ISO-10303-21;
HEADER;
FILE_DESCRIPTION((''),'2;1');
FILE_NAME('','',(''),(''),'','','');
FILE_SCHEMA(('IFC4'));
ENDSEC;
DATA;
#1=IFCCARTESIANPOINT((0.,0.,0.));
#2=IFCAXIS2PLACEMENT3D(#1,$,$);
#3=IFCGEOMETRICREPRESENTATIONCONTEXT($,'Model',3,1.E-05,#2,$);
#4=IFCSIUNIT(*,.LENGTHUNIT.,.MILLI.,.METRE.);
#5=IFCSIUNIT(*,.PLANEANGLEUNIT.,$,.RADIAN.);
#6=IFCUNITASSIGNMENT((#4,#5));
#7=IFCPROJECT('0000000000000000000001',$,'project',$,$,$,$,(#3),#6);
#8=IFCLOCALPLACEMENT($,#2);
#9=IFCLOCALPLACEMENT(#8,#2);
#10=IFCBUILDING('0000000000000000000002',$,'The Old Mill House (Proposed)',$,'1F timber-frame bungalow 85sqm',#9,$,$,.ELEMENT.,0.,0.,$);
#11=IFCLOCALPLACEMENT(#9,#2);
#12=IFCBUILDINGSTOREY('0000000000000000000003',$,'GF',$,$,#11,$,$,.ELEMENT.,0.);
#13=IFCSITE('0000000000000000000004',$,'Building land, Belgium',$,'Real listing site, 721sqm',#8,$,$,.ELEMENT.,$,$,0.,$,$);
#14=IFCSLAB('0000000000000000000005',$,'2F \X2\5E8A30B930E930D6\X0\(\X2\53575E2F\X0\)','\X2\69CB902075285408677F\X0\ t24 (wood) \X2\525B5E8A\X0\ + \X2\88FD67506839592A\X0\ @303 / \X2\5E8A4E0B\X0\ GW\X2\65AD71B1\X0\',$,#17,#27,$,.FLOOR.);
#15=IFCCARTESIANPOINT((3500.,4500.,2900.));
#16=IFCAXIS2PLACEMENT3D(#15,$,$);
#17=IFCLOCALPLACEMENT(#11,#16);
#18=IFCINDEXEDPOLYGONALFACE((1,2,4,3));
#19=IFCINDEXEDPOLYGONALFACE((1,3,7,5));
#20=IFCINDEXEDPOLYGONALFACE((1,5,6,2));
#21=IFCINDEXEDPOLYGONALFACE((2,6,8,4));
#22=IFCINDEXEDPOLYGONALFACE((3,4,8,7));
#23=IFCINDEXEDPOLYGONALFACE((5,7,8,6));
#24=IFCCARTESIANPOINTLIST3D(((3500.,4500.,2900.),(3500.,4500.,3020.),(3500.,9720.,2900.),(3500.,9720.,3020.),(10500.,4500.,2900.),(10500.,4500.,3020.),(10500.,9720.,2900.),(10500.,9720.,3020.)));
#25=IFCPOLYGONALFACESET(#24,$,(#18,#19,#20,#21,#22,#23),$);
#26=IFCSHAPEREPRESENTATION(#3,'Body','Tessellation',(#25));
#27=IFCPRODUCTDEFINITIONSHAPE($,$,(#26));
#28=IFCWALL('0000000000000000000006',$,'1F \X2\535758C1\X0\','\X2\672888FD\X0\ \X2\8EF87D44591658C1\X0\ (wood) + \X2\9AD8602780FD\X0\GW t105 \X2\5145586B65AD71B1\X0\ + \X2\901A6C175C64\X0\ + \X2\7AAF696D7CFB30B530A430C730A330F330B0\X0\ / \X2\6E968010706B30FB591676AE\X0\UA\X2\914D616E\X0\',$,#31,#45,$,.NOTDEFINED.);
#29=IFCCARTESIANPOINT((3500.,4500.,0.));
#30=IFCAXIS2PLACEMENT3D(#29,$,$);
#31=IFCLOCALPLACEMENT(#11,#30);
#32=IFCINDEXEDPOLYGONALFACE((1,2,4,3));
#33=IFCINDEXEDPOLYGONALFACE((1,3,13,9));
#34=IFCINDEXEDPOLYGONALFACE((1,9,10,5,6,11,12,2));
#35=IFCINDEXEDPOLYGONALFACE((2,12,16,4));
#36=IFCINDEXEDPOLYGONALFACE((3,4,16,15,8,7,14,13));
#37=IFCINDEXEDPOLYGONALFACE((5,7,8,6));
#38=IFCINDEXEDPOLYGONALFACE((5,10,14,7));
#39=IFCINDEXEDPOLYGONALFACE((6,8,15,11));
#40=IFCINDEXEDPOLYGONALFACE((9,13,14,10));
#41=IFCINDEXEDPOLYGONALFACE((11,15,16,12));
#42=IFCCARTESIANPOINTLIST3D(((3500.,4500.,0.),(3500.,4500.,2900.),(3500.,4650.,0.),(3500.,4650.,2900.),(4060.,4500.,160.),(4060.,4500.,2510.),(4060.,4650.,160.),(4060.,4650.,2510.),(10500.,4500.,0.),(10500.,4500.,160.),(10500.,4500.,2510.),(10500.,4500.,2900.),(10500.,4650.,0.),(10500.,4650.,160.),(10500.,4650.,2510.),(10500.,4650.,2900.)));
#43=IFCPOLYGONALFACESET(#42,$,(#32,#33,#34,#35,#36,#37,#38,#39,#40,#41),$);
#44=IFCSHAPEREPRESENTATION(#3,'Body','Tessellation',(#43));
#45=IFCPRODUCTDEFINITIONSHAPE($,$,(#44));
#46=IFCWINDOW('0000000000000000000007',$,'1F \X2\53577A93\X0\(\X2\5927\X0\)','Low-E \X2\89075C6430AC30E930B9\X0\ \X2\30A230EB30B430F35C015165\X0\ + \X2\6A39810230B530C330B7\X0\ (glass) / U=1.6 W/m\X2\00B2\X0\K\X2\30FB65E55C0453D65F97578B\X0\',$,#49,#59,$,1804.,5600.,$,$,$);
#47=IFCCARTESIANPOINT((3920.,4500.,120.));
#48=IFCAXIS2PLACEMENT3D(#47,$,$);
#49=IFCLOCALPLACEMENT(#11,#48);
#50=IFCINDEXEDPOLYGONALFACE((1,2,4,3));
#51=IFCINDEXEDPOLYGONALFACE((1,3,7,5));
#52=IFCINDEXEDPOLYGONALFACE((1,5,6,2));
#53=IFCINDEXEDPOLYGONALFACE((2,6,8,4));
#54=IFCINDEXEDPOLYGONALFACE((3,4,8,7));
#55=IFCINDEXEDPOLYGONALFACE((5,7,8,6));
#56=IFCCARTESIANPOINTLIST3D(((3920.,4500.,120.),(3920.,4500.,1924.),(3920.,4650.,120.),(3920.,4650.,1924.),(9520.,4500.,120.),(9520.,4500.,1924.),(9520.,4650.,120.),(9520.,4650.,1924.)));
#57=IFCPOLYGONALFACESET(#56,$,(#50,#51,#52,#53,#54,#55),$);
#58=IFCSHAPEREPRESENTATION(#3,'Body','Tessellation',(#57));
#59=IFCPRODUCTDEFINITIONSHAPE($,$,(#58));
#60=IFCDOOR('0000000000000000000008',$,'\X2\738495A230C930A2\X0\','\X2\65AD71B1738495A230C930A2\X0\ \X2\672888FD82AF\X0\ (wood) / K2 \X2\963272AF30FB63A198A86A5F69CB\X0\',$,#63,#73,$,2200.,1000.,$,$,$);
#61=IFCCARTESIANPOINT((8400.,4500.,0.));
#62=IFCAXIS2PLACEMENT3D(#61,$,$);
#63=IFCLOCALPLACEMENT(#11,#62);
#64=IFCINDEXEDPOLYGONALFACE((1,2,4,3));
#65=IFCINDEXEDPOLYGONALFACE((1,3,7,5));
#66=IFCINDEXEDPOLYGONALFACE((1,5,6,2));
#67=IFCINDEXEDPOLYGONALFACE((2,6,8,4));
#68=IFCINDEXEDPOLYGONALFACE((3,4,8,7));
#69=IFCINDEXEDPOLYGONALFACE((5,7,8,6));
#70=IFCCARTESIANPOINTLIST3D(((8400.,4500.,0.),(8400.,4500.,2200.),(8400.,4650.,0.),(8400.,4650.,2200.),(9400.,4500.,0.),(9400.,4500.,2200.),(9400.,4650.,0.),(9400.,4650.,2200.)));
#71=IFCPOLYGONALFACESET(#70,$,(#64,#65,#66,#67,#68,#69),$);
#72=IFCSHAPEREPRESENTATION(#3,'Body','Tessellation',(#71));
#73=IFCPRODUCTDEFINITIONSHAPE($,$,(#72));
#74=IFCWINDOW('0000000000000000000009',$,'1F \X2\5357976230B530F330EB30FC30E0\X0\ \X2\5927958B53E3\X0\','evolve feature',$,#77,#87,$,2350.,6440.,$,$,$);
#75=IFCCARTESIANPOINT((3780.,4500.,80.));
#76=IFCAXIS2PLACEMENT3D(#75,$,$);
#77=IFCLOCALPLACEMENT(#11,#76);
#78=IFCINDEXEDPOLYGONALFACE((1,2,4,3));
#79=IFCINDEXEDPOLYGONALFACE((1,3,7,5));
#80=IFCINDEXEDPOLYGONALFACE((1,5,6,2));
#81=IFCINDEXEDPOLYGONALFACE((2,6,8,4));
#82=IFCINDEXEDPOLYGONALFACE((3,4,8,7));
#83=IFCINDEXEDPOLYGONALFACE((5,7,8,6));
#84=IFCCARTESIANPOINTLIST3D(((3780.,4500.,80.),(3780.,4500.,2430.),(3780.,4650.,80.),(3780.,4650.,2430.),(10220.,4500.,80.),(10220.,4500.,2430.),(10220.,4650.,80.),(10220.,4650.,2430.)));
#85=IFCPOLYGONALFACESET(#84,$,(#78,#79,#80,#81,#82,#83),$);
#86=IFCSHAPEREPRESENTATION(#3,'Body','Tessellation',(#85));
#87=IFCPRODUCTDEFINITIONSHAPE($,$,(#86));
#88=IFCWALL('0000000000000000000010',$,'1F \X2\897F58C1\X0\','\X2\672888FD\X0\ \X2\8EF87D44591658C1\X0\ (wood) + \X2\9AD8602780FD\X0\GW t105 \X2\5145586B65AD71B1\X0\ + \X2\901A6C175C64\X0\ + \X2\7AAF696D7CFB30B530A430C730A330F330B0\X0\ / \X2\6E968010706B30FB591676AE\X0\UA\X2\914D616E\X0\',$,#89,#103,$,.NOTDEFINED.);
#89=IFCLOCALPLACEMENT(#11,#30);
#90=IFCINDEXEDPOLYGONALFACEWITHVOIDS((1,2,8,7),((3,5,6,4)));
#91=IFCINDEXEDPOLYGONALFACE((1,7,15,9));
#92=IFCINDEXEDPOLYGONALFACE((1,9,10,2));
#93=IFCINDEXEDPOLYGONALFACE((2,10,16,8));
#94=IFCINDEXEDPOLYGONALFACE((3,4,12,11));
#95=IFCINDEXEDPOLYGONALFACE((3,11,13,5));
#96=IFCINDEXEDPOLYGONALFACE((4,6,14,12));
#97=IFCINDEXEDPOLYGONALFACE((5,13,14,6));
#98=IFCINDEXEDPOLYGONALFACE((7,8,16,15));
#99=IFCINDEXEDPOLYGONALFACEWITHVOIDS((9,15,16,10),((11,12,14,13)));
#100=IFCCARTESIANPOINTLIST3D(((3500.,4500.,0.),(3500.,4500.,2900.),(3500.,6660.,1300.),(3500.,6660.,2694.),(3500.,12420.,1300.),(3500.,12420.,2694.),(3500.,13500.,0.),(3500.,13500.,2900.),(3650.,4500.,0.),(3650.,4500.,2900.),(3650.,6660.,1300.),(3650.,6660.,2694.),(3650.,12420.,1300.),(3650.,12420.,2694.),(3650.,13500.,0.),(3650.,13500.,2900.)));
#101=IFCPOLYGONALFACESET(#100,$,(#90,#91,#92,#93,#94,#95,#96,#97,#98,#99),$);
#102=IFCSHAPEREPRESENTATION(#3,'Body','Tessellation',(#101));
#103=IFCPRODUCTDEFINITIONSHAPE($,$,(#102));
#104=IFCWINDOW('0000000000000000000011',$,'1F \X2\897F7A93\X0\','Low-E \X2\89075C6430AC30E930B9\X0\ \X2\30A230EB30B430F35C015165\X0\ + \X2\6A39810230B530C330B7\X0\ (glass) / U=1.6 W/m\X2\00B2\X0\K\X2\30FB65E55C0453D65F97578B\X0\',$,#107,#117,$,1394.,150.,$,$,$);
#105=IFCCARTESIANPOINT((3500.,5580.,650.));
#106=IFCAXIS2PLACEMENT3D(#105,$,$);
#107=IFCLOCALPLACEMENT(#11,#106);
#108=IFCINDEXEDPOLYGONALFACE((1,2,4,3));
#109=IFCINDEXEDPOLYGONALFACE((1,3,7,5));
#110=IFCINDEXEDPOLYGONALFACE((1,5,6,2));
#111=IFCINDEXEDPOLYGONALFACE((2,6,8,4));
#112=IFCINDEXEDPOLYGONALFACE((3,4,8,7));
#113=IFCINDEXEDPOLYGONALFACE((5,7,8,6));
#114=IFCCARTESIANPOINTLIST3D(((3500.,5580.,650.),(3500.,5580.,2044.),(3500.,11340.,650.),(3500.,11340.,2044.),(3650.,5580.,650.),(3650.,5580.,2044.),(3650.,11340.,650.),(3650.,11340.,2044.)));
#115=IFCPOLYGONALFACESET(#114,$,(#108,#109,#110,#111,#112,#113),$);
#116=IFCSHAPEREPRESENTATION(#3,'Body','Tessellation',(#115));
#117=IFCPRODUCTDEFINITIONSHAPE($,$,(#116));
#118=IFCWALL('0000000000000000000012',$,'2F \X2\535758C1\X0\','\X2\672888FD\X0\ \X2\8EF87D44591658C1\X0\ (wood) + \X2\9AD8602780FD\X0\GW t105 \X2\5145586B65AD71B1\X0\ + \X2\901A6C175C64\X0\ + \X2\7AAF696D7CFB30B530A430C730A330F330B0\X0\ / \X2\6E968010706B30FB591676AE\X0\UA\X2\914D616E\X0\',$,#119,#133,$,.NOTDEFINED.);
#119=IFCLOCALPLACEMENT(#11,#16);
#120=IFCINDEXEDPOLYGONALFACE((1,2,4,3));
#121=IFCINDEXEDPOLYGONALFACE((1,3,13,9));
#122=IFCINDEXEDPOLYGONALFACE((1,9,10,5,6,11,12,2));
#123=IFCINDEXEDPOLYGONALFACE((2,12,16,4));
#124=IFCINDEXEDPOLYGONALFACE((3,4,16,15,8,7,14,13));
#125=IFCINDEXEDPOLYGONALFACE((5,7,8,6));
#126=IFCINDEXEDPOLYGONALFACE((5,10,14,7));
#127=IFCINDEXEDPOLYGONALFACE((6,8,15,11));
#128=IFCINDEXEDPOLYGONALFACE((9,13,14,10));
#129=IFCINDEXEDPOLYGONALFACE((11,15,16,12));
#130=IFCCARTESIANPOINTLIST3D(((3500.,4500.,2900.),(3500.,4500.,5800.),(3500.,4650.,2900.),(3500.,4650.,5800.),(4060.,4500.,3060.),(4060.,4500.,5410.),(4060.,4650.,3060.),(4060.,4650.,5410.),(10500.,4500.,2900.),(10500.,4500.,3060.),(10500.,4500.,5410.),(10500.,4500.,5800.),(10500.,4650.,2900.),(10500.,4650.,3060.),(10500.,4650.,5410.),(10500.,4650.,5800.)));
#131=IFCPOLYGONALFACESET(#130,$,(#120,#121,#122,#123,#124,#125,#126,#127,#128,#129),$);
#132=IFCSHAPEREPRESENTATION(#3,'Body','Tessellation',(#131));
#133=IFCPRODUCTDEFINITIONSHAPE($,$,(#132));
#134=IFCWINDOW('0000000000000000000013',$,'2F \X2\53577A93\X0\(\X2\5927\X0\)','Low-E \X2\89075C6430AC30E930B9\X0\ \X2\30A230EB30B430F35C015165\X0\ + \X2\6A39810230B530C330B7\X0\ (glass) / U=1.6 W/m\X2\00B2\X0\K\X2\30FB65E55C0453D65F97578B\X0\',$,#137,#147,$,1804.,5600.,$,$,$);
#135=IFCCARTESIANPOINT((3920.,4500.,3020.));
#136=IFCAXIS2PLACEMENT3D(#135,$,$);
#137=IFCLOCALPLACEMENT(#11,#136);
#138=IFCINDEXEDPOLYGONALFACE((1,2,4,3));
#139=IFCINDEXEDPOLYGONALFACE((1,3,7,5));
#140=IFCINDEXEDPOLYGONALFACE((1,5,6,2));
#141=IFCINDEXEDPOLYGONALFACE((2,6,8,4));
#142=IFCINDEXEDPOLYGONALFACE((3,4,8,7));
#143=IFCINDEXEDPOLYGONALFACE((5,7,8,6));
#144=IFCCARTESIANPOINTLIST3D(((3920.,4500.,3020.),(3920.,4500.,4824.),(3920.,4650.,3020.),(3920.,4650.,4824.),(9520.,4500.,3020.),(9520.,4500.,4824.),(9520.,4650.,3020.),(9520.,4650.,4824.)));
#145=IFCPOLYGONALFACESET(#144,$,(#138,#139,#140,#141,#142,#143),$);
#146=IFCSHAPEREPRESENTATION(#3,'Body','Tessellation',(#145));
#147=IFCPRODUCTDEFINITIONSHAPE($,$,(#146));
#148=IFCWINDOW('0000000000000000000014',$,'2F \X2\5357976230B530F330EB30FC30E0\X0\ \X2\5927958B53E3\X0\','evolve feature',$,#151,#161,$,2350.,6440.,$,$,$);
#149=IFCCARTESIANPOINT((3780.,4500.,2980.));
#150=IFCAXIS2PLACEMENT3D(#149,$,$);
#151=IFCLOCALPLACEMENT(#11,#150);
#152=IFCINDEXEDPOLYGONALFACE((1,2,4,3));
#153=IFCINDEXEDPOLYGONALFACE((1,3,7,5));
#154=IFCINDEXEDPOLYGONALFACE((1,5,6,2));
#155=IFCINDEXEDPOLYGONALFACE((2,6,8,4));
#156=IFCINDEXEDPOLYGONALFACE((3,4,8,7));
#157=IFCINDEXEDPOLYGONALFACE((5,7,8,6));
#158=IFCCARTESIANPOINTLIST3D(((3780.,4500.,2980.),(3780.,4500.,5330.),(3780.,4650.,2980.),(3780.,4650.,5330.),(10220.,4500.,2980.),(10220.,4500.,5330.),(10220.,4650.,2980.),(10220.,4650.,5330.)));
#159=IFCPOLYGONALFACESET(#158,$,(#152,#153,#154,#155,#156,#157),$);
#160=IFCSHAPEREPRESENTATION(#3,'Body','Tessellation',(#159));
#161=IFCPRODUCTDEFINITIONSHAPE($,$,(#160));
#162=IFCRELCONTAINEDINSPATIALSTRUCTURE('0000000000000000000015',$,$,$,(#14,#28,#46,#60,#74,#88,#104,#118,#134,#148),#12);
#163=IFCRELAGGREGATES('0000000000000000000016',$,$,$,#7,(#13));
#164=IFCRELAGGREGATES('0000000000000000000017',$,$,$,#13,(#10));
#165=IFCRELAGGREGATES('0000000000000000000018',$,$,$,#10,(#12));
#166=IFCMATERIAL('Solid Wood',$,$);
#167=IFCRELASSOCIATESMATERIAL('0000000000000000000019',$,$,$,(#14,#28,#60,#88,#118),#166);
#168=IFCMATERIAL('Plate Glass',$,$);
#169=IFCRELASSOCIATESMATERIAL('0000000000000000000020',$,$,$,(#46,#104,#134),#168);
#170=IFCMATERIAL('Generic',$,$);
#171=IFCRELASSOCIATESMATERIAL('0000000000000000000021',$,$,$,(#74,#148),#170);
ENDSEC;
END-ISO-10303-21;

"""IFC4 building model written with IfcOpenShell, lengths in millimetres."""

from ifc_helpers import new_model, si_unit, frame, frame_2d, origin, place, context, project, spatial, rectangle, extrude, material, element, fill, save


model = new_model("IFC4")

# Units and contexts
model_context = context("Model", 3, precision=1e-05, world=origin())
ifc_project = project(units=[si_unit("LENGTHUNIT", "METRE", prefix="MILLI"), si_unit("PLANEANGLEUNIT", "RADIAN")], contexts=[model_context])

# Site, building, storey
site_placement = place(None, origin())
site = spatial("IfcSite", under=ifc_project, at=site_placement, Name="Building land, Belgium", ObjectType="Real listing site, 721sqm", CompositionType="ELEMENT", RefElevation=0.0)
building_placement = place(site_placement, origin())
building = spatial("IfcBuilding", under=site, at=building_placement, Name="The Old Mill House (Proposed)", ObjectType="1F timber-frame bungalow 85sqm", CompositionType="ELEMENT", ElevationOfRefHeight=0.0, ElevationOfTerrain=0.0)
storey_placement = place(building_placement, origin())
storey = spatial("IfcBuildingStorey", under=building, at=storey_placement, Name="GF", CompositionType="ELEMENT", Elevation=0.0)

# Slab
ifc_material_1 = material(Name="Solid Wood")
slab_1_placement = place(storey_placement, frame((3500.0, 4500.0, 2900.0)))
element("IfcSlab", 1, at=slab_1_placement, inside=storey, material=ifc_material_1, Name="2F 床スラブ(南帯)", Description="構造用合板 t24 (wood) 剛床 + 製材根太 @303 / 床下 GW断熱", PredefinedType="FLOOR", context=model_context, shape_type="SweptSolid", body=[
    extrude(rectangle(XDim=7000.0, YDim=5220.0, at=frame_2d((3500.0, 2610.0))), frame((3500.0, 4500.0, 2900.0)), (0.0, 0.0, 1.0), 120.0),
])
ifc_material_2 = material(Name="Generic")

# Wall, openings, windows, door
wall_1_placement = place(storey_placement, frame((3500.0, 4500.0, 0.0)))
wall_1 = element("IfcWall", 2, at=wall_1_placement, inside=storey, material=ifc_material_1, Name="1F 南壁", Description="木製 軸組外壁 (wood) + 高性能GW t105 充填断熱 + 通気層 + 窯業系サイディング / 準耐火・外皮UA配慮", PredefinedType="NOTDEFINED", context=model_context, shape_type="SweptSolid", body=[
    extrude(rectangle(XDim=7000.0, YDim=150.0, at=frame_2d((3500.0, 75.0))), frame((3500.0, 4500.0, 0.0)), (0.0, 0.0, 1.0), 2900.0),
])
opening_1_placement = place(storey_placement, frame((3920.0, 4500.0, 120.0)))
opening_1 = element("IfcOpeningElement", 3, at=opening_1_placement, cuts=wall_1, PredefinedType="NOTDEFINED", context=model_context, shape_type="SweptSolid", body=[
    extrude(rectangle(XDim=5600.0, YDim=150.0, at=frame_2d((2800.0, 75.0))), frame((3920.0, 4500.0, 120.0)), (0.0, 0.0, 1.0), 1804.0),
])
opening_2_placement = place(storey_placement, frame((8400.0, 4500.0, 0.0)))
opening_2 = element("IfcOpeningElement", 4, at=opening_2_placement, cuts=wall_1, PredefinedType="NOTDEFINED", context=model_context, shape_type="SweptSolid", body=[
    extrude(rectangle(XDim=1000.0, YDim=150.0, at=frame_2d((500.0, 75.0))), frame((8400.0, 4500.0, 0.0)), (0.0, 0.0, 1.0), 2200.0),
])
opening_3_placement = place(storey_placement, frame((3780.0, 4500.0, 80.0)))
opening_3 = element("IfcOpeningElement", 5, at=opening_3_placement, cuts=wall_1, PredefinedType="NOTDEFINED", context=model_context, shape_type="SweptSolid", body=[
    extrude(rectangle(XDim=6440.0, YDim=150.0, at=frame_2d((3220.0, 75.0))), frame((3780.0, 4500.0, 80.0)), (0.0, 0.0, 1.0), 2350.0),
])
ifc_material_3 = material(Name="Plate Glass")
window_1_placement = place(storey_placement, frame((3920.0, 4500.0, 120.0)))
window_1 = element("IfcWindow", 6, at=window_1_placement, inside=storey, material=ifc_material_3, Name="1F 南窓(大)", Description="Low-E 複層ガラス アルゴン封入 + 樹脂サッシ (glass) / U=1.6 W/m²K・日射取得型", OverallHeight=1804.0, OverallWidth=5600.0, context=model_context, shape_type="SweptSolid", body=[
    extrude(rectangle(XDim=5600.0, YDim=150.0, at=frame_2d((2800.0, 75.0))), frame((3920.0, 4500.0, 120.0)), (0.0, 0.0, 1.0), 1804.0),
])
fill(opening_1, window_1)
door_placement = place(storey_placement, frame((8400.0, 4500.0, 0.0)))
door = element("IfcDoor", 7, at=door_placement, inside=storey, material=ifc_material_1, Name="玄関ドア", Description="断熱玄関ドア 木製芯 (wood) / K2 防犯・採風機構", OverallHeight=2200.0, OverallWidth=1000.0, context=model_context, shape_type="SweptSolid", body=[
    extrude(rectangle(XDim=1000.0, YDim=150.0, at=frame_2d((500.0, 75.0))), frame((8400.0, 4500.0, 0.0)), (0.0, 0.0, 1.0), 2200.0),
])
fill(opening_2, door)
window_2_placement = place(storey_placement, frame((3780.0, 4500.0, 80.0)))
window_2 = element("IfcWindow", 8, at=window_2_placement, inside=storey, material=ifc_material_2, Name="1F 南面サンルーム 大開口", Description="evolve feature", OverallHeight=2350.0, OverallWidth=6440.0, context=model_context, shape_type="SweptSolid", body=[
    extrude(rectangle(XDim=6440.0, YDim=150.0, at=frame_2d((3220.0, 75.0))), frame((3780.0, 4500.0, 80.0)), (0.0, 0.0, 1.0), 2350.0),
])
fill(opening_3, window_2)

# Wall, opening, window
wall_2_placement = place(storey_placement, frame((3500.0, 4500.0, 0.0)))
wall_2 = element("IfcWall", 9, at=wall_2_placement, inside=storey, material=ifc_material_1, Name="1F 西壁", Description="木製 軸組外壁 (wood) + 高性能GW t105 充填断熱 + 通気層 + 窯業系サイディング / 準耐火・外皮UA配慮", PredefinedType="NOTDEFINED", context=model_context, shape_type="SweptSolid", body=[
    extrude(rectangle(XDim=150.0, YDim=9000.0, at=frame_2d((75.0, 4500.0))), frame((3500.0, 4500.0, 0.0)), (0.0, 0.0, 1.0), 2900.0),
])
opening_4_placement = place(storey_placement, frame((3500.0, 5580.0, 650.0)))
opening_4 = element("IfcOpeningElement", 10, at=opening_4_placement, cuts=wall_2, PredefinedType="NOTDEFINED", context=model_context, shape_type="SweptSolid", body=[
    extrude(rectangle(XDim=150.0, YDim=5760.0, at=frame_2d((75.0, 2880.0))), frame((3500.0, 5580.0, 650.0)), (0.0, 0.0, 1.0), 1394.0),
])
window_3_placement = place(storey_placement, frame((3500.0, 5580.0, 650.0)))
window_3 = element("IfcWindow", 11, at=window_3_placement, inside=storey, material=ifc_material_3, Name="1F 西窓", Description="Low-E 複層ガラス アルゴン封入 + 樹脂サッシ (glass) / U=1.6 W/m²K・日射取得型", OverallHeight=1394.0, OverallWidth=150.0, context=model_context, shape_type="SweptSolid", body=[
    extrude(rectangle(XDim=150.0, YDim=5760.0, at=frame_2d((75.0, 2880.0))), frame((3500.0, 5580.0, 650.0)), (0.0, 0.0, 1.0), 1394.0),
])
fill(opening_4, window_3)

# Wall, openings, windows
wall_3_placement = place(storey_placement, frame((3500.0, 4500.0, 2900.0)))
wall_3 = element("IfcWall", 12, at=wall_3_placement, inside=storey, material=ifc_material_1, Name="2F 南壁", Description="木製 軸組外壁 (wood) + 高性能GW t105 充填断熱 + 通気層 + 窯業系サイディング / 準耐火・外皮UA配慮", PredefinedType="NOTDEFINED", context=model_context, shape_type="SweptSolid", body=[
    extrude(rectangle(XDim=7000.0, YDim=150.0, at=frame_2d((3500.0, 75.0))), frame((3500.0, 4500.0, 2900.0)), (0.0, 0.0, 1.0), 2900.0),
])
opening_5_placement = place(storey_placement, frame((3920.0, 4500.0, 3020.0)))
opening_5 = element("IfcOpeningElement", 13, at=opening_5_placement, cuts=wall_3, PredefinedType="NOTDEFINED", context=model_context, shape_type="SweptSolid", body=[
    extrude(rectangle(XDim=5600.0, YDim=150.0, at=frame_2d((2800.0, 75.0))), frame((3920.0, 4500.0, 3020.0)), (0.0, 0.0, 1.0), 1804.0),
])
opening_6_placement = place(storey_placement, frame((3780.0, 4500.0, 2980.0)))
opening_6 = element("IfcOpeningElement", 14, at=opening_6_placement, cuts=wall_3, PredefinedType="NOTDEFINED", context=model_context, shape_type="SweptSolid", body=[
    extrude(rectangle(XDim=6440.0, YDim=150.0, at=frame_2d((3220.0, 75.0))), frame((3780.0, 4500.0, 2980.0)), (0.0, 0.0, 1.0), 2350.0),
])
window_4_placement = place(storey_placement, frame((3920.0, 4500.0, 3020.0)))
window_4 = element("IfcWindow", 15, at=window_4_placement, inside=storey, material=ifc_material_3, Name="2F 南窓(大)", Description="Low-E 複層ガラス アルゴン封入 + 樹脂サッシ (glass) / U=1.6 W/m²K・日射取得型", OverallHeight=1804.0, OverallWidth=5600.0, context=model_context, shape_type="SweptSolid", body=[
    extrude(rectangle(XDim=5600.0, YDim=150.0, at=frame_2d((2800.0, 75.0))), frame((3920.0, 4500.0, 3020.0)), (0.0, 0.0, 1.0), 1804.0),
])
fill(opening_5, window_4)
window_5_placement = place(storey_placement, frame((3780.0, 4500.0, 2980.0)))
window_5 = element("IfcWindow", 16, at=window_5_placement, inside=storey, material=ifc_material_2, Name="2F 南面サンルーム 大開口", Description="evolve feature", OverallHeight=2350.0, OverallWidth=6440.0, context=model_context, shape_type="SweptSolid", body=[
    extrude(rectangle(XDim=6440.0, YDim=150.0, at=frame_2d((3220.0, 75.0))), frame((3780.0, 4500.0, 2980.0)), (0.0, 0.0, 1.0), 2350.0),
])
fill(opening_6, window_5)

save(model, "model.ifc")
